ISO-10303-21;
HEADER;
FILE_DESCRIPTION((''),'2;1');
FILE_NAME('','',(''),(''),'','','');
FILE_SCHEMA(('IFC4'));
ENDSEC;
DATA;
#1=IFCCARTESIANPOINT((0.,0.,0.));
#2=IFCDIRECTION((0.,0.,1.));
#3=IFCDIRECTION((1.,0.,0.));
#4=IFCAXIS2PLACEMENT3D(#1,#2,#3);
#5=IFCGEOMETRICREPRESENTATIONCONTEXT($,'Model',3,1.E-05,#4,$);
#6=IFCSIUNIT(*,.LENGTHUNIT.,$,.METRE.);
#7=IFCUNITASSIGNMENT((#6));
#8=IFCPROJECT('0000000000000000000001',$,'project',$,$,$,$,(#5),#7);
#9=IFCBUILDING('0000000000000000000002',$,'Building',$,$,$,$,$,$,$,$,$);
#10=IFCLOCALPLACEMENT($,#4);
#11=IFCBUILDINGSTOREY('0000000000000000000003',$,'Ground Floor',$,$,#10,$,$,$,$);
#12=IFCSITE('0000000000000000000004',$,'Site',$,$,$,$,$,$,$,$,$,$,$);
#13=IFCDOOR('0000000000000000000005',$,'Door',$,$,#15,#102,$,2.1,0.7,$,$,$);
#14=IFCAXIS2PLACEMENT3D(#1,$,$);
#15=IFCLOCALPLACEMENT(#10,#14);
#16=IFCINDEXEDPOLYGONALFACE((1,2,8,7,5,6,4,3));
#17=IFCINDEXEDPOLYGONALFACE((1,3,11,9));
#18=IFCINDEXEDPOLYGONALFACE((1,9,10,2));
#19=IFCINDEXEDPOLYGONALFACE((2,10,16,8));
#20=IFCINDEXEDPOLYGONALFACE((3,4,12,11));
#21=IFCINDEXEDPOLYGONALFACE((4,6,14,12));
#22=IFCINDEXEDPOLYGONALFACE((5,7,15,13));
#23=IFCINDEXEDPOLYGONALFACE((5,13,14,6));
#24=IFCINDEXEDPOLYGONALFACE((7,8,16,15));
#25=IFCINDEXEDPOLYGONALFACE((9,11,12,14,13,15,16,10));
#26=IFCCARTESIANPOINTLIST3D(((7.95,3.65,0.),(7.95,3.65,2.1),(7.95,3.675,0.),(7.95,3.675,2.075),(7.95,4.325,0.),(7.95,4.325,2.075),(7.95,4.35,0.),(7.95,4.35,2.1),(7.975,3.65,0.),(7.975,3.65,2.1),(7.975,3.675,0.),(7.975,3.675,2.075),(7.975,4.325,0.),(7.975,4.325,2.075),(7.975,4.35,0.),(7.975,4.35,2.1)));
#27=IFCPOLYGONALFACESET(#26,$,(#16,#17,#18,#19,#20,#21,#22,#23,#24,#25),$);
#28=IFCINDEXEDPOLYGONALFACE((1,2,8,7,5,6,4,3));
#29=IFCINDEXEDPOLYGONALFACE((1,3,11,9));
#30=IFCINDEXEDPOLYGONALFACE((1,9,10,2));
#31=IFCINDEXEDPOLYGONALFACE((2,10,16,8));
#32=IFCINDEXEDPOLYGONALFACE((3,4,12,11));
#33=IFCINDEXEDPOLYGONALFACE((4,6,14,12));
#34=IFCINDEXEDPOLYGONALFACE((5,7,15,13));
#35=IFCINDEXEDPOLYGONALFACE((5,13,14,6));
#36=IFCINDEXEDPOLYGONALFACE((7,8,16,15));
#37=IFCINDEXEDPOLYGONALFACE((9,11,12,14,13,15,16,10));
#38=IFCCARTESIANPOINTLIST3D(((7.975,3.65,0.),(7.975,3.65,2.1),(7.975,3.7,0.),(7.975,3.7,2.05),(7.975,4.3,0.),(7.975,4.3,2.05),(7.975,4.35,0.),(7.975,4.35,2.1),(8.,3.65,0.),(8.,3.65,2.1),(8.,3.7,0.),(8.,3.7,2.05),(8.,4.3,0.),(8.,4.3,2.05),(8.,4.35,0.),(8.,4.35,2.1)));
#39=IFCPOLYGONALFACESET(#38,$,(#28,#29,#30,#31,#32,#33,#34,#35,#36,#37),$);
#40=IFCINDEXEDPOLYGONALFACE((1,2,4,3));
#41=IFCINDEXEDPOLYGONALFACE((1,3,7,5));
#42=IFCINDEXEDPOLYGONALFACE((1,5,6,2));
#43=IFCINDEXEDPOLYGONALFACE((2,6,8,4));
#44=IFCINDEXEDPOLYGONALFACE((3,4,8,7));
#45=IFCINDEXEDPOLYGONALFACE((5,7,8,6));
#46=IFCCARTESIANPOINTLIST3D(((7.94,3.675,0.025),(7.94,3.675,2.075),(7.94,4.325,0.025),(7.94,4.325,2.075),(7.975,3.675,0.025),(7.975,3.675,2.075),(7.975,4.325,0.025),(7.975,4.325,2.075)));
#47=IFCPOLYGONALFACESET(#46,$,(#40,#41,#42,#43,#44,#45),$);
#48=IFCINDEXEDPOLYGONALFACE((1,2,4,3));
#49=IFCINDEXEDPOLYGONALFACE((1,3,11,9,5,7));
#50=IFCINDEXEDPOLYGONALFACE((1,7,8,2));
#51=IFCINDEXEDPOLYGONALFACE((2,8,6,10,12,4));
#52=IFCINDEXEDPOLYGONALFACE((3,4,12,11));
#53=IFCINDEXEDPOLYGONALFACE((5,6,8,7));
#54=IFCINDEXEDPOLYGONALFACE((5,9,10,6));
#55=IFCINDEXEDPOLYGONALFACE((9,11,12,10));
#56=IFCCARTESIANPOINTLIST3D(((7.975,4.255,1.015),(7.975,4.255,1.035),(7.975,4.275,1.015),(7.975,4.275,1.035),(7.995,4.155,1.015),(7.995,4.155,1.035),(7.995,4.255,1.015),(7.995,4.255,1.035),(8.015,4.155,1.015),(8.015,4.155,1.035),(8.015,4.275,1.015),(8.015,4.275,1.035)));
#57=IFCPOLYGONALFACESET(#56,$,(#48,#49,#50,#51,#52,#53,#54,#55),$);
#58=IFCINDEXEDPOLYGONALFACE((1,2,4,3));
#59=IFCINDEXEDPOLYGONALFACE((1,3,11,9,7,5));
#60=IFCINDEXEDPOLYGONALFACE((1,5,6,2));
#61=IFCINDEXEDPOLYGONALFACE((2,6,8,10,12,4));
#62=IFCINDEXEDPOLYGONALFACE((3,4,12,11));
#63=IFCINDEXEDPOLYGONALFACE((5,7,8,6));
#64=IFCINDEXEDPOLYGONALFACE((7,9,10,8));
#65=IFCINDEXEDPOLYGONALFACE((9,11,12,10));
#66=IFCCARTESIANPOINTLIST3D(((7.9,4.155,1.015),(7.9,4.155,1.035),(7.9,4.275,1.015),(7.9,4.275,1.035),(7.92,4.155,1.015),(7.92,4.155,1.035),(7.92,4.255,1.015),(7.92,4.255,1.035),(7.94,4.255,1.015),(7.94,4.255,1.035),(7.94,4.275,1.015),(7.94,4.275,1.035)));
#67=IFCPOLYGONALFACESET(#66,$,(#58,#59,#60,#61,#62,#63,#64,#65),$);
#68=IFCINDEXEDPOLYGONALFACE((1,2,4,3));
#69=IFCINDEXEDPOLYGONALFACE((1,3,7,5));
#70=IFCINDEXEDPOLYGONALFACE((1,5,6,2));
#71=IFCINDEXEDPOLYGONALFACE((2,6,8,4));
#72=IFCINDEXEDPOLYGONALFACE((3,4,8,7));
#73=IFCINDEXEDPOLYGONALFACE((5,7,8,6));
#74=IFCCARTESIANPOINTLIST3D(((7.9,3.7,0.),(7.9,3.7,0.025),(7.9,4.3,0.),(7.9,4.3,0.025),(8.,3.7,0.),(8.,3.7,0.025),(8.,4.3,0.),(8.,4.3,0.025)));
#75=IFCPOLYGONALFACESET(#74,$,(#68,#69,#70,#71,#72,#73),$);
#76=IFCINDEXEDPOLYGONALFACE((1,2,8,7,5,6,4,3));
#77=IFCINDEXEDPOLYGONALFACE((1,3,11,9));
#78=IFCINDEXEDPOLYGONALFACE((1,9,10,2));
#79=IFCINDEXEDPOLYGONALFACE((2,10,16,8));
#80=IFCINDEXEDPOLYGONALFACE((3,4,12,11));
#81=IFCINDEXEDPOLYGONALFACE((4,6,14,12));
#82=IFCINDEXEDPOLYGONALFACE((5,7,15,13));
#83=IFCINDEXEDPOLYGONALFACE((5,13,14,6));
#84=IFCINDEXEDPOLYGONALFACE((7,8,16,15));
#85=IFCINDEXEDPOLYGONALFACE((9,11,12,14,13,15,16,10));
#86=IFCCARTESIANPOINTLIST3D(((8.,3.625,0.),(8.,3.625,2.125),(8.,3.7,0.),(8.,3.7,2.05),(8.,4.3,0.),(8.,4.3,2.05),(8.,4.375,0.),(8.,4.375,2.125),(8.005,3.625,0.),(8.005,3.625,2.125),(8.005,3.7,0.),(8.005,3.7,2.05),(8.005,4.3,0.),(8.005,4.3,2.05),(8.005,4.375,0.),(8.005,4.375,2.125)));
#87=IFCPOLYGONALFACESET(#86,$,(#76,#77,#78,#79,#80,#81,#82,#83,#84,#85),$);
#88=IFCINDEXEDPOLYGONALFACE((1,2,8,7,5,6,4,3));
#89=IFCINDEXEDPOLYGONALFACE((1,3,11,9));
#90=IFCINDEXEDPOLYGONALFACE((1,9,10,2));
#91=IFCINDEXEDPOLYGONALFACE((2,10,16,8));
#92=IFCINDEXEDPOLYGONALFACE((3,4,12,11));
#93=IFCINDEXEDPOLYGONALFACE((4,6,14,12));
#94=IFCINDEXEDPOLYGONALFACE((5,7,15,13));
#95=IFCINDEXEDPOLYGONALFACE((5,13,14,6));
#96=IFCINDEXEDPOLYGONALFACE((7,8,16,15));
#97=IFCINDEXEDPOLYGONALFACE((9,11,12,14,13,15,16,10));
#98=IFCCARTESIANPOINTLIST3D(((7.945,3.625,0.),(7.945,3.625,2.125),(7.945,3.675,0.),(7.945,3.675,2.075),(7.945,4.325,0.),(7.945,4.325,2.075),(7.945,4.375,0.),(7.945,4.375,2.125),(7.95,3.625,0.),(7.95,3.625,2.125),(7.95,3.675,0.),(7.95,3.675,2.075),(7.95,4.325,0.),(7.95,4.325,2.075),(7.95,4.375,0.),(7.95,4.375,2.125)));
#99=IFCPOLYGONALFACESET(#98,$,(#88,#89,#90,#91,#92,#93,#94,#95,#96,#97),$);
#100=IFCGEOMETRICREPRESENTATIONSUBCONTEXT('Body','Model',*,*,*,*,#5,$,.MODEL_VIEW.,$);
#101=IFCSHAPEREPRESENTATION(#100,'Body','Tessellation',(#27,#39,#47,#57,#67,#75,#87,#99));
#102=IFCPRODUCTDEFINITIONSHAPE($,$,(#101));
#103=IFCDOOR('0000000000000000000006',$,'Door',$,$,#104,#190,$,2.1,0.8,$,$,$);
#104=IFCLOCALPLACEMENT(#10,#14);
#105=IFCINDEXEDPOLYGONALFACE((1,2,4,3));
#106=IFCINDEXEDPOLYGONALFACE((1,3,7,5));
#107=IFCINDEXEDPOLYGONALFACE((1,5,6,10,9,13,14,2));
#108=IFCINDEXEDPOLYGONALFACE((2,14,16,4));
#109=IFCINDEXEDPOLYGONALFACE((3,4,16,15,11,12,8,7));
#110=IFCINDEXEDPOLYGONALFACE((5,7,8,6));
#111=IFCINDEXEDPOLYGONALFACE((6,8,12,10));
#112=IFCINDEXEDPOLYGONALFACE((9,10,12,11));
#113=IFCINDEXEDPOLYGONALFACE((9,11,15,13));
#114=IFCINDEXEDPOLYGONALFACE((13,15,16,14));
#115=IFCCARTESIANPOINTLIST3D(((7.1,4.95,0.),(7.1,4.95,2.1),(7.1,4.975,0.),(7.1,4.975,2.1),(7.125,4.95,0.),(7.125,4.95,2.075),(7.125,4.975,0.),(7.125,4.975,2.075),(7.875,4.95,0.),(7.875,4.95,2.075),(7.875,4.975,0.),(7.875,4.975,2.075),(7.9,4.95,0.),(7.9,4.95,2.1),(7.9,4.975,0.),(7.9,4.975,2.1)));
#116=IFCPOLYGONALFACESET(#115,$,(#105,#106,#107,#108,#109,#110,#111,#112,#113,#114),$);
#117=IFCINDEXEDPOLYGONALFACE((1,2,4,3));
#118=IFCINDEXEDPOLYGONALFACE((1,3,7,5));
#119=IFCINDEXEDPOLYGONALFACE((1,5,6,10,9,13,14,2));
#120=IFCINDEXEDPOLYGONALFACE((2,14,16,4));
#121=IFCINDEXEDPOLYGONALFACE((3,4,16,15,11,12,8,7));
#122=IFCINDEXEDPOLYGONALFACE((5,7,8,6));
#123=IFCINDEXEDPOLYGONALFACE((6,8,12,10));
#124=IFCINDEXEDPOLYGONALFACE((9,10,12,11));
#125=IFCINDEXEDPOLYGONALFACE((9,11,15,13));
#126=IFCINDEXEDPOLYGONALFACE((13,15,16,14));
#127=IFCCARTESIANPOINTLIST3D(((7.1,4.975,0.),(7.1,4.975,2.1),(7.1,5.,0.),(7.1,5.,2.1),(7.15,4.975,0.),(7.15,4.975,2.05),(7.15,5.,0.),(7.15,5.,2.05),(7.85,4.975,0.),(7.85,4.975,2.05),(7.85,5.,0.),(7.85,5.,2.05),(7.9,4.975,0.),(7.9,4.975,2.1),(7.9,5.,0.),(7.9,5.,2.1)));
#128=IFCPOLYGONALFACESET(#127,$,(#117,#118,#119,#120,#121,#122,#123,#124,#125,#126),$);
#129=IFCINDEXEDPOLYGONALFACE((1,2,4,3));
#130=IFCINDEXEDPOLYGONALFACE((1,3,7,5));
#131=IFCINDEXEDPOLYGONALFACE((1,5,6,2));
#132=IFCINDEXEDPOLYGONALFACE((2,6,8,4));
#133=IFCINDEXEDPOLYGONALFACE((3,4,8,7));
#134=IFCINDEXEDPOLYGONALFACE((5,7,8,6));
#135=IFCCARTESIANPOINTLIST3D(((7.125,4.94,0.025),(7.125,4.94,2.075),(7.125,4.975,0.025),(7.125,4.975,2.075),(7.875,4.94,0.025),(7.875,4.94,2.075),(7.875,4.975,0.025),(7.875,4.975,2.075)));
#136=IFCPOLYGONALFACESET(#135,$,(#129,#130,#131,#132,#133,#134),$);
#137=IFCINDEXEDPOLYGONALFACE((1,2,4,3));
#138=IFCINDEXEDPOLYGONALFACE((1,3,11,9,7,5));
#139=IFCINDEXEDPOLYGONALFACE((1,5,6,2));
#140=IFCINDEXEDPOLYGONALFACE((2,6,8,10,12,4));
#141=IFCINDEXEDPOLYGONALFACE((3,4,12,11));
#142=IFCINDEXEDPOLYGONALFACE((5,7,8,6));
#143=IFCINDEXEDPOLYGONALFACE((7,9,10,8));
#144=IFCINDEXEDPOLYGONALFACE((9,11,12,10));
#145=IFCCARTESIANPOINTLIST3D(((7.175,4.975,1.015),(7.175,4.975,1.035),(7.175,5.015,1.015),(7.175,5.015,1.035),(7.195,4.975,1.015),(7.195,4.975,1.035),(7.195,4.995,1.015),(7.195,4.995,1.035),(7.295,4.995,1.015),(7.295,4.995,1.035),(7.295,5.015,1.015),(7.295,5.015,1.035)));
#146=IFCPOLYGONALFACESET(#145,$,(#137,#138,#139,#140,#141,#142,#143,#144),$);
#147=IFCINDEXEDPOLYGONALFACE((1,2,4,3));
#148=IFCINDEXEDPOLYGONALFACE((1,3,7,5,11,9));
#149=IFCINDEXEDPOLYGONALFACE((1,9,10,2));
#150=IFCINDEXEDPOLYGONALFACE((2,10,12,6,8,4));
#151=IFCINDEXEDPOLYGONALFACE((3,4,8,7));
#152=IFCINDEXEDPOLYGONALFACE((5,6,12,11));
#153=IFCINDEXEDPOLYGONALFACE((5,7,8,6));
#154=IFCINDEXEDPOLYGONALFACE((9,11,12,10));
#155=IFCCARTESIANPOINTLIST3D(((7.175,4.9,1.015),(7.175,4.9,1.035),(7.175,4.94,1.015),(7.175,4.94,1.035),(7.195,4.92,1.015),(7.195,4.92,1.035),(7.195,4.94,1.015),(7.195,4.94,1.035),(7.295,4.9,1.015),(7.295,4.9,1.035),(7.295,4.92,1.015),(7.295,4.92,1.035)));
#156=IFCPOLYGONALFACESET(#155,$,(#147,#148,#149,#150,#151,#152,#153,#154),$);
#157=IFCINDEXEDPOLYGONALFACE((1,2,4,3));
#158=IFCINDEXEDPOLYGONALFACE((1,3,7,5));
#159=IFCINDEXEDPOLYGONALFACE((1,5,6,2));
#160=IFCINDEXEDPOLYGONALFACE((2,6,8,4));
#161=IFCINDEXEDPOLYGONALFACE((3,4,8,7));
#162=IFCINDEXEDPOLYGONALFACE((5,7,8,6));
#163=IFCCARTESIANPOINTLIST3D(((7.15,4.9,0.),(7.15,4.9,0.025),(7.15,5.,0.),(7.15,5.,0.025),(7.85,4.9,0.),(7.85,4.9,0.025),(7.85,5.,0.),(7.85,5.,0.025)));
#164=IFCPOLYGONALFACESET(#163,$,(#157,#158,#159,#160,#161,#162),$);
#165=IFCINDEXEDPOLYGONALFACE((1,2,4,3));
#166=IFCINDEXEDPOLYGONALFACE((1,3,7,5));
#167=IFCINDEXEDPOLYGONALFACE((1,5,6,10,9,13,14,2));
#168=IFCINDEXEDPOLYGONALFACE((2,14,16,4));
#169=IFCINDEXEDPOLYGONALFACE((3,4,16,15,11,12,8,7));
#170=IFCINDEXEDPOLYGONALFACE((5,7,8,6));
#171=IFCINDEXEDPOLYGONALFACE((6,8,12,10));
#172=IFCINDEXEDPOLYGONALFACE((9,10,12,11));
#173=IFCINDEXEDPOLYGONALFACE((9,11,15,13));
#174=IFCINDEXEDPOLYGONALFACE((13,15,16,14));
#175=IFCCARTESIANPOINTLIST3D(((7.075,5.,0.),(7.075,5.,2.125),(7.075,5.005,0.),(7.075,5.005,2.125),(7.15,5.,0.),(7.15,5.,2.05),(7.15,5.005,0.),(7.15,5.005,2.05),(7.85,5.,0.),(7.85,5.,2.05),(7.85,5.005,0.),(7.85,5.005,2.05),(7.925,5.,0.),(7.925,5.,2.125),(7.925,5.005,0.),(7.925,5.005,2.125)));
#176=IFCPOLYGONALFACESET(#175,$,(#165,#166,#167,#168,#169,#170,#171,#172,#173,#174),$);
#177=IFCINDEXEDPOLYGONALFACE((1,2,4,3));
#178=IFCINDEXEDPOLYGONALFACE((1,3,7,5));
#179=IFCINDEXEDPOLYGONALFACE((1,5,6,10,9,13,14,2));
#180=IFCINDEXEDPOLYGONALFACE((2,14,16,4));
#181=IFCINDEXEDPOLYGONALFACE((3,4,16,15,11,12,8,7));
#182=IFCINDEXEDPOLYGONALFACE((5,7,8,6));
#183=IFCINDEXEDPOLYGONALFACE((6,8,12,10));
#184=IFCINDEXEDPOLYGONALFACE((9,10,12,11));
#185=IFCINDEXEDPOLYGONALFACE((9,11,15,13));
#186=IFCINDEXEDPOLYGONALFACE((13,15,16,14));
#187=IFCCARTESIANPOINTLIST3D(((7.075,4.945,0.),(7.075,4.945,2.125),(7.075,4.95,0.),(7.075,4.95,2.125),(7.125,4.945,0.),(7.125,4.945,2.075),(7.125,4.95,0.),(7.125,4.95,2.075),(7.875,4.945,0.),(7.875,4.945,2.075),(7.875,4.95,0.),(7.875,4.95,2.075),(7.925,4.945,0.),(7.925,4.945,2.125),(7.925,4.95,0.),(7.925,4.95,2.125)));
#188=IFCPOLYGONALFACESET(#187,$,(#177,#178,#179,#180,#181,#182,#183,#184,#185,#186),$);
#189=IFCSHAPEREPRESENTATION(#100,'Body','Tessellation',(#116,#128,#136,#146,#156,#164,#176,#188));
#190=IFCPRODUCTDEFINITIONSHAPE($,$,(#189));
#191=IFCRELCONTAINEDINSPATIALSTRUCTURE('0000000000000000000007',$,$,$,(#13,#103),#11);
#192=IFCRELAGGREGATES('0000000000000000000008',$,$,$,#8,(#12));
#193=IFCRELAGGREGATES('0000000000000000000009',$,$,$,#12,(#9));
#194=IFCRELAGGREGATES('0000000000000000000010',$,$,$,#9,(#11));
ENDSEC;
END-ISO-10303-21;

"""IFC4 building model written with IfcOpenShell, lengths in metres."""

from ifc_helpers import new_model, si_unit, frame, origin_with_axes, place, context, subcontext, project, spatial, line, indexed_curve, outline, extrude, element, save


model = new_model("IFC4")

# Units and contexts
model_context = context("Model", 3, precision=1e-05, world=origin_with_axes())
body_context = subcontext(model_context, "Body", "Model", "MODEL_VIEW")
ifc_project = project(units=[si_unit("LENGTHUNIT", "METRE")], contexts=[model_context])

# Site, building, storey
site = spatial("IfcSite", under=ifc_project, Name="Site")
building = spatial("IfcBuilding", under=site, Name="Building")
storey_placement = place(None, origin_with_axes())
storey = spatial("IfcBuildingStorey", under=building, at=storey_placement, Name="Ground Floor")

# Doors
door_1_placement = place(storey_placement, frame((8.0, 3.65, 0.0), z_axis=(0.0, 0.0, 1.0), x_axis=(0.0, 1.0, 0.0)))
element("IfcDoor", 1, at=door_1_placement, inside=storey, Name="Door", OverallHeight=2.1, OverallWidth=0.7, context=body_context, shape_type="SweptSolid", body=[
    extrude(outline(indexed_curve([(0.0, 0.0), (0.0, 2.1), (0.7, 2.1), (0.7, 0.0), (0.675, 0.0), (0.675, 2.075), (0.025, 2.075), (0.025, 0.0)], segments=[line(1, 2, 3, 4, 5, 6, 7, 8, 1)])), frame((0.0, 0.025, 0.0), z_axis=(0.0, -1.0, 0.0), x_axis=(1.0, 0.0, 0.0)), (0.0, 0.0, -1.0), 0.025),
    extrude(outline(indexed_curve([(0.0, 0.0), (0.0, 2.1), (0.7, 2.1), (0.7, 0.0), (0.65, 0.0), (0.65, 2.05), (0.05, 2.05), (0.05, 0.0)], segments=[line(1, 2, 3, 4, 5, 6, 7, 8, 1)])), frame((0.0, 0.0, 0.0), z_axis=(0.0, -1.0, 0.0), x_axis=(1.0, 0.0, 0.0)), (0.0, 0.0, -1.0), 0.025),
    extrude(outline(indexed_curve([(0.0, 0.0), (0.65, 0.0), (0.65, 0.035), (0.0, 0.035)], segments=[line(1, 2, 3, 4, 1)])), frame((0.025, 0.025, 0.025), z_axis=(0.0, 0.0, 1.0), x_axis=(1.0, 0.0, 0.0)), (0.0, 0.0, 1.0), 2.05),
    extrude(outline(indexed_curve([(0.0, 0.0), (0.0, -0.04), (-0.12, -0.04), (-0.12, -0.02), (-0.02, -0.02), (-0.02, 0.0)], segments=[line(1, 2, 3, 4, 5, 6, 1)])), frame((0.625, 0.025, 1.015), z_axis=(0.0, 0.0, 1.0), x_axis=(1.0, 0.0, 0.0)), (0.0, 0.0, 1.0), 0.02),
    extrude(outline(indexed_curve([(0.0, 0.0), (0.0, 0.04), (-0.12, 0.04), (-0.12, 0.02), (-0.02, 0.02), (-0.02, 0.0)], segments=[line(1, 2, 3, 4, 5, 6, 1)])), frame((0.625, 0.06, 1.015), z_axis=(0.0, 0.0, 1.0), x_axis=(1.0, 0.0, 0.0)), (0.0, 0.0, 1.0), 0.02),
    extrude(outline(indexed_curve([(0.0, 0.0), (0.6, 0.0), (0.6, 0.1), (0.0, 0.1)], segments=[line(1, 2, 3, 4, 1)])), frame((0.05, 0.0, 0.0), z_axis=(0.0, 0.0, 1.0), x_axis=(1.0, 0.0, 0.0)), (0.0, 0.0, 1.0), 0.025),
    extrude(outline(indexed_curve([(0.0, 0.0), (0.0, 2.125), (0.75, 2.125), (0.75, 0.0), (0.675, 0.0), (0.675, 2.05), (0.075, 2.05), (0.075, 0.0)], segments=[line(1, 2, 3, 4, 5, 6, 7, 8, 1)])), frame((-0.025, -0.005, 0.0), z_axis=(0.0, -1.0, 0.0), x_axis=(1.0, 0.0, 0.0)), (0.0, 0.0, -1.0), 0.005),
    extrude(outline(indexed_curve([(0.0, 0.0), (0.0, 2.125), (0.75, 2.125), (0.75, 0.0), (0.7, 0.0), (0.7, 2.075), (0.05, 2.075), (0.05, 0.0)], segments=[line(1, 2, 3, 4, 5, 6, 7, 8, 1)])), frame((-0.025, 0.05, 0.0), z_axis=(0.0, -1.0, 0.0), x_axis=(1.0, 0.0, 0.0)), (0.0, 0.0, -1.0), 0.005),
])
door_2_placement = place(storey_placement, frame((7.9, 5.0, 0.0), z_axis=(0.0, 0.0, 1.0), x_axis=(-1.0, 0.0, 0.0)))
element("IfcDoor", 2, at=door_2_placement, inside=storey, Name="Door", OverallHeight=2.1, OverallWidth=0.8, context=body_context, shape_type="SweptSolid", body=[
    extrude(outline(indexed_curve([(0.0, 0.0), (0.0, 2.1), (0.8, 2.1), (0.8, 0.0), (0.775, 0.0), (0.775, 2.075), (0.025, 2.075), (0.025, 0.0)], segments=[line(1, 2, 3, 4, 5, 6, 7, 8, 1)])), frame((0.0, 0.025, 0.0), z_axis=(0.0, -1.0, 0.0), x_axis=(1.0, 0.0, 0.0)), (0.0, 0.0, -1.0), 0.025),
    extrude(outline(indexed_curve([(0.0, 0.0), (0.0, 2.1), (0.8, 2.1), (0.8, 0.0), (0.75, 0.0), (0.75, 2.05), (0.05, 2.05), (0.05, 0.0)], segments=[line(1, 2, 3, 4, 5, 6, 7, 8, 1)])), frame((0.0, 0.0, 0.0), z_axis=(0.0, -1.0, 0.0), x_axis=(1.0, 0.0, 0.0)), (0.0, 0.0, -1.0), 0.025),
    extrude(outline(indexed_curve([(0.0, 0.0), (0.75, 0.0), (0.75, 0.035), (0.0, 0.035)], segments=[line(1, 2, 3, 4, 1)])), frame((0.025, 0.025, 0.025), z_axis=(0.0, 0.0, 1.0), x_axis=(1.0, 0.0, 0.0)), (0.0, 0.0, 1.0), 2.05),
    extrude(outline(indexed_curve([(0.0, 0.0), (0.0, -0.04), (-0.12, -0.04), (-0.12, -0.02), (-0.02, -0.02), (-0.02, 0.0)], segments=[line(1, 2, 3, 4, 5, 6, 1)])), frame((0.725, 0.025, 1.015), z_axis=(0.0, 0.0, 1.0), x_axis=(1.0, 0.0, 0.0)), (0.0, 0.0, 1.0), 0.02),
    extrude(outline(indexed_curve([(0.0, 0.0), (0.0, 0.04), (-0.12, 0.04), (-0.12, 0.02), (-0.02, 0.02), (-0.02, 0.0)], segments=[line(1, 2, 3, 4, 5, 6, 1)])), frame((0.725, 0.06, 1.015), z_axis=(0.0, 0.0, 1.0), x_axis=(1.0, 0.0, 0.0)), (0.0, 0.0, 1.0), 0.02),
    extrude(outline(indexed_curve([(0.0, 0.0), (0.7, 0.0), (0.7, 0.1), (0.0, 0.1)], segments=[line(1, 2, 3, 4, 1)])), frame((0.05, 0.0, 0.0), z_axis=(0.0, 0.0, 1.0), x_axis=(1.0, 0.0, 0.0)), (0.0, 0.0, 1.0), 0.025),
    extrude(outline(indexed_curve([(0.0, 0.0), (0.0, 2.125), (0.85, 2.125), (0.85, 0.0), (0.775, 0.0), (0.775, 2.05), (0.075, 2.05), (0.075, 0.0)], segments=[line(1, 2, 3, 4, 5, 6, 7, 8, 1)])), frame((-0.025, -0.005, 0.0), z_axis=(0.0, -1.0, 0.0), x_axis=(1.0, 0.0, 0.0)), (0.0, 0.0, -1.0), 0.005),
    extrude(outline(indexed_curve([(0.0, 0.0), (0.0, 2.125), (0.85, 2.125), (0.85, 0.0), (0.8, 0.0), (0.8, 2.075), (0.05, 2.075), (0.05, 0.0)], segments=[line(1, 2, 3, 4, 5, 6, 7, 8, 1)])), frame((-0.025, 0.05, 0.0), z_axis=(0.0, -1.0, 0.0), x_axis=(1.0, 0.0, 0.0)), (0.0, 0.0, -1.0), 0.005),
])

save(model, "model.ifc")
